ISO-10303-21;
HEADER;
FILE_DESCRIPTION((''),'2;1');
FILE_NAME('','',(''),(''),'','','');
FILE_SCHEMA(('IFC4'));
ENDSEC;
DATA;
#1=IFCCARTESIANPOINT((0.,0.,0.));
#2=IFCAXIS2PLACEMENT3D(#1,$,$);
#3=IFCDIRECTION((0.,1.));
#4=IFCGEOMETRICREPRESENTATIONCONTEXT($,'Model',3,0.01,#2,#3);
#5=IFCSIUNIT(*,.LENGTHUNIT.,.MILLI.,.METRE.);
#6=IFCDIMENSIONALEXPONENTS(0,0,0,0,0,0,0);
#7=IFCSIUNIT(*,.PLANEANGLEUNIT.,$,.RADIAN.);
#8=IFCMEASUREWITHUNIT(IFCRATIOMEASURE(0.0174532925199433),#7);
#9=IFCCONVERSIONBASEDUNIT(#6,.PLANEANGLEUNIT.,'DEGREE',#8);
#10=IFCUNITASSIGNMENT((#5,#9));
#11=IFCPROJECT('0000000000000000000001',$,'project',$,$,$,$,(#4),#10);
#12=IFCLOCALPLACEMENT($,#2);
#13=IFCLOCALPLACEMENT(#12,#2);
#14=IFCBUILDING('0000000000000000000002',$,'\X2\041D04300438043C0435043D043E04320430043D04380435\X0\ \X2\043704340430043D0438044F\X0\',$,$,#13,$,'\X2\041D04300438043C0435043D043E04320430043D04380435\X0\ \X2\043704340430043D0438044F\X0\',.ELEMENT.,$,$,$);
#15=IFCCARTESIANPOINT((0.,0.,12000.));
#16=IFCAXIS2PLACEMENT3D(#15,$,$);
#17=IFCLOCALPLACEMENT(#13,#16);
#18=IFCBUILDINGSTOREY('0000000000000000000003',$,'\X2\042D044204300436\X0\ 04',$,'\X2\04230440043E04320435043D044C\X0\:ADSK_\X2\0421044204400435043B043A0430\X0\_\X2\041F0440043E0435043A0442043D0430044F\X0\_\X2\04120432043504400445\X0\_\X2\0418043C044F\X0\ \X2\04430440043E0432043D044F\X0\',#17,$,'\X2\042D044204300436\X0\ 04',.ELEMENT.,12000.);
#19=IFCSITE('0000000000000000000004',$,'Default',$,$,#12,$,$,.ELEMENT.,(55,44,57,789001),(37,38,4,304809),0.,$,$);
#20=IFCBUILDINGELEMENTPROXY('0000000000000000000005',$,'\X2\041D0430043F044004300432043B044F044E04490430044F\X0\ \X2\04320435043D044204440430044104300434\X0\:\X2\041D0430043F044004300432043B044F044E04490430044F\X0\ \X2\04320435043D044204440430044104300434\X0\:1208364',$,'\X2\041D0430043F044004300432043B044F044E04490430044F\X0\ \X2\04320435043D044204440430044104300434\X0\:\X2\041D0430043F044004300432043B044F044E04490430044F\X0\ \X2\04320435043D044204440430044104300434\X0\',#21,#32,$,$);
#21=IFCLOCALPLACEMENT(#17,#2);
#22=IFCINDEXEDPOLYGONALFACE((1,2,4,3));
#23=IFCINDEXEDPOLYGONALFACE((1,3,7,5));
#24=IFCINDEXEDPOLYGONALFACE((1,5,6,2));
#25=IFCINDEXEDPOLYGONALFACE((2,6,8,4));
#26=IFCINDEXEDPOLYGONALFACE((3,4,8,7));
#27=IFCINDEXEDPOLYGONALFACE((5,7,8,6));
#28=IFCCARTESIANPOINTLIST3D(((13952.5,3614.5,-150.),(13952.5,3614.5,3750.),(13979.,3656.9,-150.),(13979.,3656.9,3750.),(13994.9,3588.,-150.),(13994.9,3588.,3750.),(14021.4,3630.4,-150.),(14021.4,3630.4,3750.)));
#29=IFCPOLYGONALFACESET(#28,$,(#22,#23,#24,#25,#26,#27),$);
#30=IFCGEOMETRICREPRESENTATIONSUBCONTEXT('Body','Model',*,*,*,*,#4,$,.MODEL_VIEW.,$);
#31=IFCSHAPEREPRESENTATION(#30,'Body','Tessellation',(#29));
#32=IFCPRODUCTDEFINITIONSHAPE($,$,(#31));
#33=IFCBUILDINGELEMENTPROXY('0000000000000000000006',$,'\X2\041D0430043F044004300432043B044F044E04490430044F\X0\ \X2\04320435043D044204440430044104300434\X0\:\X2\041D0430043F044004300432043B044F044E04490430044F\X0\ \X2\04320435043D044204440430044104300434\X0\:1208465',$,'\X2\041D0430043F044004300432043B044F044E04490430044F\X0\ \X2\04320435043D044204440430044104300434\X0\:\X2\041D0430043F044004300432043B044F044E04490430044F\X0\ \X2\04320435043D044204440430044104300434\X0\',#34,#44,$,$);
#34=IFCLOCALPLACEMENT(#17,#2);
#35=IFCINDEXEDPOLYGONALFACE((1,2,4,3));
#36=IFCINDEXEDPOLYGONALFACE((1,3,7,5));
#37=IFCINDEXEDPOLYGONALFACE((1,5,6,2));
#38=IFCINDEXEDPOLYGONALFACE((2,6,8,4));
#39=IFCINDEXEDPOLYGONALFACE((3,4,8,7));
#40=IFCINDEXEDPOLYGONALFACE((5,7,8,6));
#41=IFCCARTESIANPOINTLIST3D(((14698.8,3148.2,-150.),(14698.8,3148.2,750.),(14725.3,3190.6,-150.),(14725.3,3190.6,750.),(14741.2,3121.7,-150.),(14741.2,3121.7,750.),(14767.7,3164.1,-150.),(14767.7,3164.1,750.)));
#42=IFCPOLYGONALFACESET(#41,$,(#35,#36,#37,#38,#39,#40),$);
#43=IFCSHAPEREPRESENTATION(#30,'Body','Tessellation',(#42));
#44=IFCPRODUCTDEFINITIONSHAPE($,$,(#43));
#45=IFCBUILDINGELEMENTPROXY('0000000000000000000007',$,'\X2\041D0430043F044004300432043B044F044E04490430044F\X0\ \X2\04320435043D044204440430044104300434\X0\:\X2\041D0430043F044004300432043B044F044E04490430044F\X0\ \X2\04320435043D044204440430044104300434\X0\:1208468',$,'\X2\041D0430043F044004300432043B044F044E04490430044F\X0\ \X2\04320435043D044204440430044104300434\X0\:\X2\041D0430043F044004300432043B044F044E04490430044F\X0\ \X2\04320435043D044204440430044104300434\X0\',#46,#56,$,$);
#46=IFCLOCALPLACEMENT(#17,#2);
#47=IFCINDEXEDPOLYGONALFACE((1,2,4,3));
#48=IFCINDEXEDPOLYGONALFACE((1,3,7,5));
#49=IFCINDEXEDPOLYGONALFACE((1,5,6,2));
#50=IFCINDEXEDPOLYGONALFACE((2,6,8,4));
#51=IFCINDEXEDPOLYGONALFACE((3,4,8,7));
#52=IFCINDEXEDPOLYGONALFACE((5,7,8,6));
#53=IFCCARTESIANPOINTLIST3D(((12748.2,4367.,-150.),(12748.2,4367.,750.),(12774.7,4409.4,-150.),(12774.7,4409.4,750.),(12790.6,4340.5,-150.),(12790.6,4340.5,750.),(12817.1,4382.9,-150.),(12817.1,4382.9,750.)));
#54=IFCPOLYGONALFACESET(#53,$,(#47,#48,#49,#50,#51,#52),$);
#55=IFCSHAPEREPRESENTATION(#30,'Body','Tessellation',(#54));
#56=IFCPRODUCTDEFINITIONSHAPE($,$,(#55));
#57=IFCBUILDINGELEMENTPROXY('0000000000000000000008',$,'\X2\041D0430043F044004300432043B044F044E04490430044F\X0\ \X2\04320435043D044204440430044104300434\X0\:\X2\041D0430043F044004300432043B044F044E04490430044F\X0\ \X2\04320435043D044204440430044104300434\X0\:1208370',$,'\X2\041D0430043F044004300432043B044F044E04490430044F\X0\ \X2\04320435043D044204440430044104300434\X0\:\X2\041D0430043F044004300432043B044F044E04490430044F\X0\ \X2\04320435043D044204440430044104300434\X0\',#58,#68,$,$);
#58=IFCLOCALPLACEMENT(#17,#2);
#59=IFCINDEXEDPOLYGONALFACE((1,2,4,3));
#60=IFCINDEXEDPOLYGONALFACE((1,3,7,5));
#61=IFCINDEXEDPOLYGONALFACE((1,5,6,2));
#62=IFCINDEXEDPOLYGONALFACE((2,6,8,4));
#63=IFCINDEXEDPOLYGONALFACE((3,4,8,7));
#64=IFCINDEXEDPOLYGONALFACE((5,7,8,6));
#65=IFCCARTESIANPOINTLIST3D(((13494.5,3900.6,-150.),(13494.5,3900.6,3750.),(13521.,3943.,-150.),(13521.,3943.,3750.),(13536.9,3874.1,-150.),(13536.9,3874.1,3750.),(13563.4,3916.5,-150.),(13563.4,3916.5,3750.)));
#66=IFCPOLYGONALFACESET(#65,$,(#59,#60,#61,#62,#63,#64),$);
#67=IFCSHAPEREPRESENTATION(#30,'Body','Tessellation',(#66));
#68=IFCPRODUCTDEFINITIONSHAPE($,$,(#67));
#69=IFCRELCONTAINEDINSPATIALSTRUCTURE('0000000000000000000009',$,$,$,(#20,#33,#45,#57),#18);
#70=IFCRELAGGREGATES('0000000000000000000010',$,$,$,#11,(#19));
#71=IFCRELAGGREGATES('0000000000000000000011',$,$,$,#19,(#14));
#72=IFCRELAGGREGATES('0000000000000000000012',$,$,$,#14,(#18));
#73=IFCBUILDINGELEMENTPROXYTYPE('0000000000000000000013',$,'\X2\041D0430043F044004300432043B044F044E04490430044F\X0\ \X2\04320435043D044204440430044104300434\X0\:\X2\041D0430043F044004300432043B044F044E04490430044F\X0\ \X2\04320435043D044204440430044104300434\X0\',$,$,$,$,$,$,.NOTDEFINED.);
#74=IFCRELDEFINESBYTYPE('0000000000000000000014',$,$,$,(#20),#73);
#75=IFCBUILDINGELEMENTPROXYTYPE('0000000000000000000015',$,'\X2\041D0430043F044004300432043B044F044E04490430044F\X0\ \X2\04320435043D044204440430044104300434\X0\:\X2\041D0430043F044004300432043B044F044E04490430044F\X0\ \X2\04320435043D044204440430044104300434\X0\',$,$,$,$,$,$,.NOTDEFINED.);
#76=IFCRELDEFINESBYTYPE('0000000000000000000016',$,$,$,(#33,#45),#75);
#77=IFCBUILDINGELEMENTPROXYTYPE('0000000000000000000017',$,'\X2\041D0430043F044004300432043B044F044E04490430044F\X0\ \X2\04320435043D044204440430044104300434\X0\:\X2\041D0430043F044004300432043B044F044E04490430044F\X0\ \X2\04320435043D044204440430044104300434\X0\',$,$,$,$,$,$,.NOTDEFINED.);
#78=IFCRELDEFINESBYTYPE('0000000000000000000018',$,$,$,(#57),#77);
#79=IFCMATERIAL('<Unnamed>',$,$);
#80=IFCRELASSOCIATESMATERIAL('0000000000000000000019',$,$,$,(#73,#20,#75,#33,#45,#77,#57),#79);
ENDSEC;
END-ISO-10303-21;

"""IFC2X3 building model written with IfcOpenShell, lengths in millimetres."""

from ifc_helpers import new_model, entity, si_unit, converted_unit, direction, frame, origin, origin_2d_with_axis, place, context, subcontext, project, spatial, rectangle, extrude, source, transform, mapped, material, type_object, type_shapes, element, save


model = new_model("IFC2X3")

# Units and contexts
model_context = context("Model", 3, precision=0.01, world=origin(), true_north=direction((0.0, 1.0)))
body_context = subcontext(model_context, "Body", "Model", "MODEL_VIEW")
ifc_project = project(units=[si_unit("LENGTHUNIT", "METRE", prefix="MILLI"), converted_unit("PLANEANGLEUNIT", "DEGREE", entity("IfcRatioMeasure", 0.0174532925199433), si_unit("PLANEANGLEUNIT", "RADIAN"), dimensions=[0, 0, 0, 0, 0, 0, 0])], contexts=[model_context])

# Site, building, storey
site_placement = place(None, origin())
site = spatial("IfcSite", under=ifc_project, at=site_placement, Name="Default", CompositionType="ELEMENT", RefLatitude=(55, 44, 57, 789001), RefLongitude=(37, 38, 4, 304809), RefElevation=0.0)
building_placement = place(site_placement, origin())
building = spatial("IfcBuilding", under=site, at=building_placement, Name="Наименование здания", LongName="Наименование здания", CompositionType="ELEMENT")
storey_placement = place(building_placement, frame((0.0, 0.0, 12000.0)))
storey = spatial("IfcBuildingStorey", under=building, at=storey_placement, Name="Этаж 04", ObjectType="Уровень:ADSK_Стрелка_Проектная_Вверх_Имя уровня", LongName="Этаж 04", CompositionType="ELEMENT", Elevation=12000.0)

# Building element proxies
ifc_material_1 = material(Name="<Unnamed>")
building_element_proxy_type_1 = type_object("IfcBuildingElementProxyType", Name="Направляющая вентфасад:Направляющая вентфасад", PredefinedType="NOTDEFINED", material=ifc_material_1)
shared_shape_1 = source(origin(), body_context, "Body", "SweptSolid", [
    extrude(rectangle(XDim=50.0, YDim=50.0, at=origin_2d_with_axis()), frame((25.0, -25.0, 0.0), z_axis=(0.0, 0.0, 1.0), x_axis=(-1.0, 0.0, 0.0)), (0.0, 0.0, 1.0), 3900.0),
])
type_shapes(building_element_proxy_type_1, [shared_shape_1])
proxy_1_placement = place(storey_placement, frame((13979.0, 3656.9, -150.0), z_axis=(0.0, 0.0, 1.0), x_axis=(0.848053, -0.529912, 0.0)))
element("IfcBuildingElementProxy", 1, at=proxy_1_placement, inside=storey, type_object=building_element_proxy_type_1, material=ifc_material_1, Name="Направляющая вентфасад:Направляющая вентфасад:1208364", ObjectType="Направляющая вентфасад:Направляющая вентфасад", context=body_context, shape_type="MappedRepresentation", body=[
    mapped(shared_shape_1, transform((0.0, 0.0, 0.0), scale=1.0)),
])
building_element_proxy_type_2 = type_object("IfcBuildingElementProxyType", Name="Направляющая вентфасад:Направляющая вентфасад", PredefinedType="NOTDEFINED", material=ifc_material_1)
shared_shape_2 = source(origin(), body_context, "Body", "SweptSolid", [
    extrude(rectangle(XDim=50.0, YDim=50.0, at=origin_2d_with_axis()), frame((25.0, -25.0, 0.0), z_axis=(0.0, 0.0, 1.0), x_axis=(-1.0, 0.0, 0.0)), (0.0, 0.0, 1.0), 900.0),
])
type_shapes(building_element_proxy_type_2, [shared_shape_2])
for number, where, z_axis, x_axis, name in (
    (2, (14725.3, 3190.6, -150.0), (0.0, 0.0, 1.0), (0.848053, -0.529912, 0.0), "Направляющая вентфасад:Направляющая вентфасад:1208465"),
    (3, (12774.7, 4409.4, -150.0), (0.0, 0.0, 1.0), (0.848053, -0.529912, 0.0), "Направляющая вентфасад:Направляющая вентфасад:1208468"),
):
    element("IfcBuildingElementProxy", number, at=place(storey_placement, frame(where, z_axis=z_axis, x_axis=x_axis)), inside=storey, type_object=building_element_proxy_type_2, material=ifc_material_1, Name=name, ObjectType="Направляющая вентфасад:Направляющая вентфасад", context=body_context, shape_type="MappedRepresentation", body=[
        mapped(shared_shape_2, transform((0.0, 0.0, 0.0), scale=1.0)),
    ])
building_element_proxy_type_3 = type_object("IfcBuildingElementProxyType", Name="Направляющая вентфасад:Направляющая вентфасад", PredefinedType="NOTDEFINED", material=ifc_material_1)
shared_shape_3 = source(origin(), body_context, "Body", "SweptSolid", [
    extrude(rectangle(XDim=50.0, YDim=50.0, at=origin_2d_with_axis()), frame((25.0, 25.0, 0.0), z_axis=(0.0, 0.0, 1.0), x_axis=(0.0, 1.0, 0.0)), (0.0, 0.0, 1.0), 3900.0),
])
type_shapes(building_element_proxy_type_3, [shared_shape_3])
proxy_2_placement = place(storey_placement, frame((13563.4, 3916.5, -150.0), z_axis=(0.0, 0.0, 1.0), x_axis=(-0.848053, 0.529912, 0.0)))
element("IfcBuildingElementProxy", 4, at=proxy_2_placement, inside=storey, type_object=building_element_proxy_type_3, material=ifc_material_1, Name="Направляющая вентфасад:Направляющая вентфасад:1208370", ObjectType="Направляющая вентфасад:Направляющая вентфасад", context=body_context, shape_type="MappedRepresentation", body=[
    mapped(shared_shape_3, transform((0.0, 0.0, 0.0), scale=1.0)),
])

save(model, "model.ifc")
